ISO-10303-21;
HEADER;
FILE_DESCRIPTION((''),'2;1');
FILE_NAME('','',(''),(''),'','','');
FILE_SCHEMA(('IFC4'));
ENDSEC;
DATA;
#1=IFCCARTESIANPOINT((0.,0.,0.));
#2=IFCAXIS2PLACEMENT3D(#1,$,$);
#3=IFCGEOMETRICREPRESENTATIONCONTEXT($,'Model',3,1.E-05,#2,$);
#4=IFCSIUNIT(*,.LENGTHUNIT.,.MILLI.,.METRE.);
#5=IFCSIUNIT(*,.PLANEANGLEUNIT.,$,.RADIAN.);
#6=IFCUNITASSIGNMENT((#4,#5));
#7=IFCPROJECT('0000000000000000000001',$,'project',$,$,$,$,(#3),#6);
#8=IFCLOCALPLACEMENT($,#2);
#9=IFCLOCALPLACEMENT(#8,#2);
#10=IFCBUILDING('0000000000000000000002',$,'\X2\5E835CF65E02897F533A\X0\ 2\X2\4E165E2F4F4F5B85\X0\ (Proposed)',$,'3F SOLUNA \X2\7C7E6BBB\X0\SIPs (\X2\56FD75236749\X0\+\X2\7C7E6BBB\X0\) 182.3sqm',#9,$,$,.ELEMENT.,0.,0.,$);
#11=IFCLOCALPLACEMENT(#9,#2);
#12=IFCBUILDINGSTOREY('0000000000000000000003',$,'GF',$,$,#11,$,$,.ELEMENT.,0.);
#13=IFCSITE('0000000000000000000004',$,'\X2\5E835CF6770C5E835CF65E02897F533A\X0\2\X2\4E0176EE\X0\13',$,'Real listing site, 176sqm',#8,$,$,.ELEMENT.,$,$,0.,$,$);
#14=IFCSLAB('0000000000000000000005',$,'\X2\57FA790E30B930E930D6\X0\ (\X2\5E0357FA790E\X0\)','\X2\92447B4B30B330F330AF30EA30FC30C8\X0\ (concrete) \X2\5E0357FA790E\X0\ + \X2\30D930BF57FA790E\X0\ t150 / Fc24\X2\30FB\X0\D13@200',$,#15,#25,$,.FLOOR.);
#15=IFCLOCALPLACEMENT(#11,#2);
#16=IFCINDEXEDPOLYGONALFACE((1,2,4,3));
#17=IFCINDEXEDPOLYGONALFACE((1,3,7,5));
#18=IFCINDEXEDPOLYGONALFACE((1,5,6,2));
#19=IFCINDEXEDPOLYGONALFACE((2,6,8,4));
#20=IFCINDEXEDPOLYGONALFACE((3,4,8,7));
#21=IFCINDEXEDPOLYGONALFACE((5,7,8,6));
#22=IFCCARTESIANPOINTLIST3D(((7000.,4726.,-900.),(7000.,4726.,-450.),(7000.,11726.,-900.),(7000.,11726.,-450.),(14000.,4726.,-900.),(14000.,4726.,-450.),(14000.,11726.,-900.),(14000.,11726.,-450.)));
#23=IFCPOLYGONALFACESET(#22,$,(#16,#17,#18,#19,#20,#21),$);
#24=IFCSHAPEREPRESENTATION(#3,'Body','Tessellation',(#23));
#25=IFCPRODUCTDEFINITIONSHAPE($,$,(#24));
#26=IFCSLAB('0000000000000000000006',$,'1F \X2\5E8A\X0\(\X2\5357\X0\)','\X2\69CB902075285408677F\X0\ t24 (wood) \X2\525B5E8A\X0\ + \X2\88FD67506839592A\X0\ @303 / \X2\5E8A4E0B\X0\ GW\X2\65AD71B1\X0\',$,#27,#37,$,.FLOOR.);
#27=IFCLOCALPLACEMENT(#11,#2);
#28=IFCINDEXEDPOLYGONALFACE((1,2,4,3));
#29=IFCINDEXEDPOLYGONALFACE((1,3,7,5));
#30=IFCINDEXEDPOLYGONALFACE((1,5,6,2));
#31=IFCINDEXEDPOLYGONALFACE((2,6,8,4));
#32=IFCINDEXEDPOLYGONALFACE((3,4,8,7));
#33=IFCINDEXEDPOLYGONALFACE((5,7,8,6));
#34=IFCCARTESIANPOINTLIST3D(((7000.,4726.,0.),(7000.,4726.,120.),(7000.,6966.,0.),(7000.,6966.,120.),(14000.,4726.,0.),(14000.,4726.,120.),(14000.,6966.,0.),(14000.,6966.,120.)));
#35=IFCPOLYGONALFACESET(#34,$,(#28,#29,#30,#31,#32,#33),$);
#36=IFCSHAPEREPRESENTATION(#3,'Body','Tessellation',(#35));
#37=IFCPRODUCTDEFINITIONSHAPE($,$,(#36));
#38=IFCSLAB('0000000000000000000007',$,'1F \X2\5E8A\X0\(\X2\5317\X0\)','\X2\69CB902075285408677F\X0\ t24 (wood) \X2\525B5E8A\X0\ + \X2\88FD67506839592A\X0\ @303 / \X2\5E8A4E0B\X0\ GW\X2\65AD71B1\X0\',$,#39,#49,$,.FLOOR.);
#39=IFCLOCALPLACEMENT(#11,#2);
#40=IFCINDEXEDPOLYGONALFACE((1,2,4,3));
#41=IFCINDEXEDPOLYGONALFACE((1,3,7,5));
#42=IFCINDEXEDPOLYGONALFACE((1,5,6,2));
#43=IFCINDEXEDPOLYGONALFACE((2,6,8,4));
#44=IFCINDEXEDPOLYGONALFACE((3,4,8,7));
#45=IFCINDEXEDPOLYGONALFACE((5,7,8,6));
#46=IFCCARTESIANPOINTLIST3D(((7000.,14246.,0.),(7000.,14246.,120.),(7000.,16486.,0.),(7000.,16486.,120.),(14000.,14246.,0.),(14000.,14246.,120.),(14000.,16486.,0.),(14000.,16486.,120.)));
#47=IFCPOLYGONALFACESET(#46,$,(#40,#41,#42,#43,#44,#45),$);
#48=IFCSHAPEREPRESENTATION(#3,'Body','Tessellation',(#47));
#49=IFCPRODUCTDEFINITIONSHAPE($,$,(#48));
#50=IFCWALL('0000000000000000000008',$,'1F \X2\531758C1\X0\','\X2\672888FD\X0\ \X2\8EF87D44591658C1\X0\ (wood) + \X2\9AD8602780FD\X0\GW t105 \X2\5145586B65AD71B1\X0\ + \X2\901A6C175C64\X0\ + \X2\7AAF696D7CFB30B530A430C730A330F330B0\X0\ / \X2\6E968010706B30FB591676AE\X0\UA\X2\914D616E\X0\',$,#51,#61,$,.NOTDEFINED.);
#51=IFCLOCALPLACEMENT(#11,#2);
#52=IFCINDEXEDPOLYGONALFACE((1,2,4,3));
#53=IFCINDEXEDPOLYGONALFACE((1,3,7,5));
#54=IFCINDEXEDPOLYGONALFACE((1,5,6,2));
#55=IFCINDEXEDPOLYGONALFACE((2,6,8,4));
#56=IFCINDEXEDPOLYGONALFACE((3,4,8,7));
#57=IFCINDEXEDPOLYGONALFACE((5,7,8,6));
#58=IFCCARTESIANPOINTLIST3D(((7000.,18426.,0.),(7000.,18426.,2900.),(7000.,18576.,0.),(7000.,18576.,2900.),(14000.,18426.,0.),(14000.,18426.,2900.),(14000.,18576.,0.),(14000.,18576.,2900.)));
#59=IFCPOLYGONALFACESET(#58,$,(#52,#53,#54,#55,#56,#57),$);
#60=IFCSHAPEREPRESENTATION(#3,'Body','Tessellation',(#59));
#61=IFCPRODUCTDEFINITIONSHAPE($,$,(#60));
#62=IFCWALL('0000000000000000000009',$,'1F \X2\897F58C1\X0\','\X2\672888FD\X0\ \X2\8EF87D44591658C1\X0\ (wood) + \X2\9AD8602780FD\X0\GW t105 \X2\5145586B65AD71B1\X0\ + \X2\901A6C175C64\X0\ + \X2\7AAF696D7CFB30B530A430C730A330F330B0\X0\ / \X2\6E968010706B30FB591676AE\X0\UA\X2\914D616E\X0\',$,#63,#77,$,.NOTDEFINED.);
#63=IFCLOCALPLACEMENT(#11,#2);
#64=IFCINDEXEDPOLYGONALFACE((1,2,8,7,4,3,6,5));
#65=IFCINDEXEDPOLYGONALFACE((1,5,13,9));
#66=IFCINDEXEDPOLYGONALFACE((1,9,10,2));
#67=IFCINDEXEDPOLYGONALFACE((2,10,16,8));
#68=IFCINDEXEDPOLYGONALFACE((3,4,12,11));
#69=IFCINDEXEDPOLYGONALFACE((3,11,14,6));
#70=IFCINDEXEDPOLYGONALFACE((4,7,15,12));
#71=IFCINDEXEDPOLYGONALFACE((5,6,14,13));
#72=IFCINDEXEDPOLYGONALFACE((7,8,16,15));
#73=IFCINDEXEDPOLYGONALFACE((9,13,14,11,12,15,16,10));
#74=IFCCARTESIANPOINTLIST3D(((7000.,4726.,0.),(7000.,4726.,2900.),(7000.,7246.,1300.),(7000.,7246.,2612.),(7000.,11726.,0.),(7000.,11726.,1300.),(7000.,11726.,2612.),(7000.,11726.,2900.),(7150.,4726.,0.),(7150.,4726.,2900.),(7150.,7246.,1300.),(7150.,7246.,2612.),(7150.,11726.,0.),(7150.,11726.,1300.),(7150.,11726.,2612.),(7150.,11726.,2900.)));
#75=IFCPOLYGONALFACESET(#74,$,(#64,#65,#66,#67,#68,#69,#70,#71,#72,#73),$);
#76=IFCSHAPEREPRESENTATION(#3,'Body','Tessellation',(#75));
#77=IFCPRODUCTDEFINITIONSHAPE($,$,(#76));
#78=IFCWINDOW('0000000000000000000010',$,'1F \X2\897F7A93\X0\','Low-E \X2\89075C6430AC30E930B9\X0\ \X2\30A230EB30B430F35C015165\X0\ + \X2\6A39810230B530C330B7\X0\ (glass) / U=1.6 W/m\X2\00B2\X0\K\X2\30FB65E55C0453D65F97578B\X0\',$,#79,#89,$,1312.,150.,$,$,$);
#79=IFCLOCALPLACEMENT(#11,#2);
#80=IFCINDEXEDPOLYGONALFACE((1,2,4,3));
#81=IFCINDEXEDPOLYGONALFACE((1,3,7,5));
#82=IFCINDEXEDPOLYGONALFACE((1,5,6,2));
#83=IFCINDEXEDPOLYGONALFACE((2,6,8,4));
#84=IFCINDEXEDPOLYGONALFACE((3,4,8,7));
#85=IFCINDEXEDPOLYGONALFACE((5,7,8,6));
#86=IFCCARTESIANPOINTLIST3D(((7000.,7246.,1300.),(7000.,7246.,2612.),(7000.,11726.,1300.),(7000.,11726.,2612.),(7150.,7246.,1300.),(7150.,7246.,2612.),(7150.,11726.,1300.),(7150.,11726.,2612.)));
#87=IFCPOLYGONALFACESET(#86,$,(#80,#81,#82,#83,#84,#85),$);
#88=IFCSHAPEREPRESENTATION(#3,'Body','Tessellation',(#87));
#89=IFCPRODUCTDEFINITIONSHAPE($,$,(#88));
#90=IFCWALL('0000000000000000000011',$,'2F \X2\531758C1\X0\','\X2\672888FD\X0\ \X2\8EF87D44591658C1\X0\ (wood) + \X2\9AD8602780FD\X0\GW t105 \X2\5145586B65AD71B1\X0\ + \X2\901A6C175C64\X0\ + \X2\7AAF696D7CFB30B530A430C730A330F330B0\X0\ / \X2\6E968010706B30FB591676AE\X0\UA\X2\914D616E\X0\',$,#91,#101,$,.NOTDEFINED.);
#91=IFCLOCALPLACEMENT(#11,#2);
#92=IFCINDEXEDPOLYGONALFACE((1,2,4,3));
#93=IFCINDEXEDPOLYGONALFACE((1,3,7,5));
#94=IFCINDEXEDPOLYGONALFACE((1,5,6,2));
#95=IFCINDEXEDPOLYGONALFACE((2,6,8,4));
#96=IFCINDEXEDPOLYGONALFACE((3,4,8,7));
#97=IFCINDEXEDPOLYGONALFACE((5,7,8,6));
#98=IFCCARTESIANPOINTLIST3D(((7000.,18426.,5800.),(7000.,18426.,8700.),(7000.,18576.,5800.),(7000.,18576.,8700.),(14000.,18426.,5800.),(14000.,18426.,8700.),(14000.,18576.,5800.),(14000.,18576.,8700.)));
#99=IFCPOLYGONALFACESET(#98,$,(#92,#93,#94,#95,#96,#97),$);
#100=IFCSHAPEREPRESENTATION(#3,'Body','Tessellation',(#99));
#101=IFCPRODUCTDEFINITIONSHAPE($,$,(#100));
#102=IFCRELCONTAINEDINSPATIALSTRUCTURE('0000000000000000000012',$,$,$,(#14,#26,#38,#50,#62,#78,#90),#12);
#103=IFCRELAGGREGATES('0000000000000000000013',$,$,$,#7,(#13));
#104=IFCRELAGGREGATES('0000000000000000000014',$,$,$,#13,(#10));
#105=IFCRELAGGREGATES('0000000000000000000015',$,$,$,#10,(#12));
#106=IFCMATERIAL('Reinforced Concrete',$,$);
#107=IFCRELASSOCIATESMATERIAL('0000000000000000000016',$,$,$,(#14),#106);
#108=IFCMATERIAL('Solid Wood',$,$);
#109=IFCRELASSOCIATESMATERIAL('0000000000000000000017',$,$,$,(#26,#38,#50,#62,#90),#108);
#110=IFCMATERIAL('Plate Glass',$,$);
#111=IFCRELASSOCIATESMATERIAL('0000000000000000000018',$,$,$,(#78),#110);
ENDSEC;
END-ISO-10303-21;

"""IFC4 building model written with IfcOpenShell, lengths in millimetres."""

from ifc_helpers import new_model, si_unit, frame, frame_2d, origin, place, context, project, spatial, rectangle, extrude, material, element, fill, save


model = new_model("IFC4")

# Units and contexts
model_context = context("Model", 3, precision=1e-05, world=origin())
ifc_project = project(units=[si_unit("LENGTHUNIT", "METRE", prefix="MILLI"), si_unit("PLANEANGLEUNIT", "RADIAN")], contexts=[model_context])

# Site, building, storey
site_placement = place(None, origin())
site = spatial("IfcSite", under=ifc_project, at=site_placement, Name="広島県広島市西区2丁目13", ObjectType="Real listing site, 176sqm", CompositionType="ELEMENT", RefElevation=0.0)
building_placement = place(site_placement, origin())
building = spatial("IfcBuilding", under=site, at=building_placement, Name="広島市西区 2世帯住宅 (Proposed)", ObjectType="3F SOLUNA 籾殻SIPs (国産杉+籾殻) 182.3sqm", CompositionType="ELEMENT", ElevationOfRefHeight=0.0, ElevationOfTerrain=0.0)
storey_placement = place(building_placement, origin())
storey = spatial("IfcBuildingStorey", under=building, at=storey_placement, Name="GF", CompositionType="ELEMENT", Elevation=0.0)

# Slabs
ifc_material_1 = material(Name="Reinforced Concrete")
slab_1_placement = place(storey_placement, frame((3500.0, 2363.0, -450.0)))
element("IfcSlab", 1, at=slab_1_placement, inside=storey, material=ifc_material_1, Name="基礎スラブ (布基礎)", Description="鉄筋コンクリート (concrete) 布基礎 + ベタ基礎 t150 / Fc24・D13@200", PredefinedType="FLOOR", context=model_context, shape_type="SweptSolid", body=[
    extrude(rectangle(XDim=7000.0, YDim=7000.0, at=frame_2d((3500.0, 3500.0))), frame((3500.0, 2363.0, -450.0)), (0.0, 0.0, 1.0), 450.0),
])
ifc_material_2 = material(Name="Solid Wood")
slab_2_placement = place(storey_placement, frame((3500.0, 2363.0, 0.0)))
element("IfcSlab", 2, at=slab_2_placement, inside=storey, material=ifc_material_2, Name="1F 床(南)", Description="構造用合板 t24 (wood) 剛床 + 製材根太 @303 / 床下 GW断熱", PredefinedType="FLOOR", context=model_context, shape_type="SweptSolid", body=[
    extrude(rectangle(XDim=7000.0, YDim=2240.0, at=frame_2d((3500.0, 1120.0))), frame((3500.0, 2363.0, 0.0)), (0.0, 0.0, 1.0), 120.0),
])
slab_3_placement = place(storey_placement, frame((3500.0, 7123.0, 0.0)))
element("IfcSlab", 3, at=slab_3_placement, inside=storey, material=ifc_material_2, Name="1F 床(北)", Description="構造用合板 t24 (wood) 剛床 + 製材根太 @303 / 床下 GW断熱", PredefinedType="FLOOR", context=model_context, shape_type="SweptSolid", body=[
    extrude(rectangle(XDim=7000.0, YDim=2240.0, at=frame_2d((3500.0, 1120.0))), frame((3500.0, 7123.0, 0.0)), (0.0, 0.0, 1.0), 120.0),
])

# Shared definitions
ifc_material_3 = material(Name="Plate Glass")

# Wall
wall_1_placement = place(storey_placement, frame((3500.0, 9213.0, 0.0)))
element("IfcWall", 4, at=wall_1_placement, inside=storey, material=ifc_material_2, Name="1F 北壁", Description="木製 軸組外壁 (wood) + 高性能GW t105 充填断熱 + 通気層 + 窯業系サイディング / 準耐火・外皮UA配慮", PredefinedType="NOTDEFINED", context=model_context, shape_type="SweptSolid", body=[
    extrude(rectangle(XDim=7000.0, YDim=150.0, at=frame_2d((3500.0, 75.0))), frame((3500.0, 9213.0, 0.0)), (0.0, 0.0, 1.0), 2900.0),
])

# Wall, opening, window
wall_2_placement = place(storey_placement, frame((3500.0, 2363.0, 0.0)))
wall_2 = element("IfcWall", 5, at=wall_2_placement, inside=storey, material=ifc_material_2, Name="1F 西壁", Description="木製 軸組外壁 (wood) + 高性能GW t105 充填断熱 + 通気層 + 窯業系サイディング / 準耐火・外皮UA配慮", PredefinedType="NOTDEFINED", context=model_context, shape_type="SweptSolid", body=[
    extrude(rectangle(XDim=150.0, YDim=7000.0, at=frame_2d((75.0, 3500.0))), frame((3500.0, 2363.0, 0.0)), (0.0, 0.0, 1.0), 2900.0),
])
opening_1_placement = place(storey_placement, frame((3500.0, 3623.0, 650.0)))
opening_1 = element("IfcOpeningElement", 6, at=opening_1_placement, cuts=wall_2, PredefinedType="NOTDEFINED", context=model_context, shape_type="SweptSolid", body=[
    extrude(rectangle(XDim=150.0, YDim=4480.0, at=frame_2d((75.0, 2240.0))), frame((3500.0, 3623.0, 650.0)), (0.0, 0.0, 1.0), 1312.0),
])
window_1_placement = place(storey_placement, frame((3500.0, 3623.0, 650.0)))
window_1 = element("IfcWindow", 7, at=window_1_placement, inside=storey, material=ifc_material_3, Name="1F 西窓", Description="Low-E 複層ガラス アルゴン封入 + 樹脂サッシ (glass) / U=1.6 W/m²K・日射取得型", OverallHeight=1312.0, OverallWidth=150.0, context=model_context, shape_type="SweptSolid", body=[
    extrude(rectangle(XDim=150.0, YDim=4480.0, at=frame_2d((75.0, 2240.0))), frame((3500.0, 3623.0, 650.0)), (0.0, 0.0, 1.0), 1312.0),
])
fill(opening_1, window_1)

# Wall
wall_3_placement = place(storey_placement, frame((3500.0, 9213.0, 2900.0)))
element("IfcWall", 8, at=wall_3_placement, inside=storey, material=ifc_material_2, Name="2F 北壁", Description="木製 軸組外壁 (wood) + 高性能GW t105 充填断熱 + 通気層 + 窯業系サイディング / 準耐火・外皮UA配慮", PredefinedType="NOTDEFINED", context=model_context, shape_type="SweptSolid", body=[
    extrude(rectangle(XDim=7000.0, YDim=150.0, at=frame_2d((3500.0, 75.0))), frame((3500.0, 9213.0, 2900.0)), (0.0, 0.0, 1.0), 2900.0),
])

save(model, "model.ifc")
